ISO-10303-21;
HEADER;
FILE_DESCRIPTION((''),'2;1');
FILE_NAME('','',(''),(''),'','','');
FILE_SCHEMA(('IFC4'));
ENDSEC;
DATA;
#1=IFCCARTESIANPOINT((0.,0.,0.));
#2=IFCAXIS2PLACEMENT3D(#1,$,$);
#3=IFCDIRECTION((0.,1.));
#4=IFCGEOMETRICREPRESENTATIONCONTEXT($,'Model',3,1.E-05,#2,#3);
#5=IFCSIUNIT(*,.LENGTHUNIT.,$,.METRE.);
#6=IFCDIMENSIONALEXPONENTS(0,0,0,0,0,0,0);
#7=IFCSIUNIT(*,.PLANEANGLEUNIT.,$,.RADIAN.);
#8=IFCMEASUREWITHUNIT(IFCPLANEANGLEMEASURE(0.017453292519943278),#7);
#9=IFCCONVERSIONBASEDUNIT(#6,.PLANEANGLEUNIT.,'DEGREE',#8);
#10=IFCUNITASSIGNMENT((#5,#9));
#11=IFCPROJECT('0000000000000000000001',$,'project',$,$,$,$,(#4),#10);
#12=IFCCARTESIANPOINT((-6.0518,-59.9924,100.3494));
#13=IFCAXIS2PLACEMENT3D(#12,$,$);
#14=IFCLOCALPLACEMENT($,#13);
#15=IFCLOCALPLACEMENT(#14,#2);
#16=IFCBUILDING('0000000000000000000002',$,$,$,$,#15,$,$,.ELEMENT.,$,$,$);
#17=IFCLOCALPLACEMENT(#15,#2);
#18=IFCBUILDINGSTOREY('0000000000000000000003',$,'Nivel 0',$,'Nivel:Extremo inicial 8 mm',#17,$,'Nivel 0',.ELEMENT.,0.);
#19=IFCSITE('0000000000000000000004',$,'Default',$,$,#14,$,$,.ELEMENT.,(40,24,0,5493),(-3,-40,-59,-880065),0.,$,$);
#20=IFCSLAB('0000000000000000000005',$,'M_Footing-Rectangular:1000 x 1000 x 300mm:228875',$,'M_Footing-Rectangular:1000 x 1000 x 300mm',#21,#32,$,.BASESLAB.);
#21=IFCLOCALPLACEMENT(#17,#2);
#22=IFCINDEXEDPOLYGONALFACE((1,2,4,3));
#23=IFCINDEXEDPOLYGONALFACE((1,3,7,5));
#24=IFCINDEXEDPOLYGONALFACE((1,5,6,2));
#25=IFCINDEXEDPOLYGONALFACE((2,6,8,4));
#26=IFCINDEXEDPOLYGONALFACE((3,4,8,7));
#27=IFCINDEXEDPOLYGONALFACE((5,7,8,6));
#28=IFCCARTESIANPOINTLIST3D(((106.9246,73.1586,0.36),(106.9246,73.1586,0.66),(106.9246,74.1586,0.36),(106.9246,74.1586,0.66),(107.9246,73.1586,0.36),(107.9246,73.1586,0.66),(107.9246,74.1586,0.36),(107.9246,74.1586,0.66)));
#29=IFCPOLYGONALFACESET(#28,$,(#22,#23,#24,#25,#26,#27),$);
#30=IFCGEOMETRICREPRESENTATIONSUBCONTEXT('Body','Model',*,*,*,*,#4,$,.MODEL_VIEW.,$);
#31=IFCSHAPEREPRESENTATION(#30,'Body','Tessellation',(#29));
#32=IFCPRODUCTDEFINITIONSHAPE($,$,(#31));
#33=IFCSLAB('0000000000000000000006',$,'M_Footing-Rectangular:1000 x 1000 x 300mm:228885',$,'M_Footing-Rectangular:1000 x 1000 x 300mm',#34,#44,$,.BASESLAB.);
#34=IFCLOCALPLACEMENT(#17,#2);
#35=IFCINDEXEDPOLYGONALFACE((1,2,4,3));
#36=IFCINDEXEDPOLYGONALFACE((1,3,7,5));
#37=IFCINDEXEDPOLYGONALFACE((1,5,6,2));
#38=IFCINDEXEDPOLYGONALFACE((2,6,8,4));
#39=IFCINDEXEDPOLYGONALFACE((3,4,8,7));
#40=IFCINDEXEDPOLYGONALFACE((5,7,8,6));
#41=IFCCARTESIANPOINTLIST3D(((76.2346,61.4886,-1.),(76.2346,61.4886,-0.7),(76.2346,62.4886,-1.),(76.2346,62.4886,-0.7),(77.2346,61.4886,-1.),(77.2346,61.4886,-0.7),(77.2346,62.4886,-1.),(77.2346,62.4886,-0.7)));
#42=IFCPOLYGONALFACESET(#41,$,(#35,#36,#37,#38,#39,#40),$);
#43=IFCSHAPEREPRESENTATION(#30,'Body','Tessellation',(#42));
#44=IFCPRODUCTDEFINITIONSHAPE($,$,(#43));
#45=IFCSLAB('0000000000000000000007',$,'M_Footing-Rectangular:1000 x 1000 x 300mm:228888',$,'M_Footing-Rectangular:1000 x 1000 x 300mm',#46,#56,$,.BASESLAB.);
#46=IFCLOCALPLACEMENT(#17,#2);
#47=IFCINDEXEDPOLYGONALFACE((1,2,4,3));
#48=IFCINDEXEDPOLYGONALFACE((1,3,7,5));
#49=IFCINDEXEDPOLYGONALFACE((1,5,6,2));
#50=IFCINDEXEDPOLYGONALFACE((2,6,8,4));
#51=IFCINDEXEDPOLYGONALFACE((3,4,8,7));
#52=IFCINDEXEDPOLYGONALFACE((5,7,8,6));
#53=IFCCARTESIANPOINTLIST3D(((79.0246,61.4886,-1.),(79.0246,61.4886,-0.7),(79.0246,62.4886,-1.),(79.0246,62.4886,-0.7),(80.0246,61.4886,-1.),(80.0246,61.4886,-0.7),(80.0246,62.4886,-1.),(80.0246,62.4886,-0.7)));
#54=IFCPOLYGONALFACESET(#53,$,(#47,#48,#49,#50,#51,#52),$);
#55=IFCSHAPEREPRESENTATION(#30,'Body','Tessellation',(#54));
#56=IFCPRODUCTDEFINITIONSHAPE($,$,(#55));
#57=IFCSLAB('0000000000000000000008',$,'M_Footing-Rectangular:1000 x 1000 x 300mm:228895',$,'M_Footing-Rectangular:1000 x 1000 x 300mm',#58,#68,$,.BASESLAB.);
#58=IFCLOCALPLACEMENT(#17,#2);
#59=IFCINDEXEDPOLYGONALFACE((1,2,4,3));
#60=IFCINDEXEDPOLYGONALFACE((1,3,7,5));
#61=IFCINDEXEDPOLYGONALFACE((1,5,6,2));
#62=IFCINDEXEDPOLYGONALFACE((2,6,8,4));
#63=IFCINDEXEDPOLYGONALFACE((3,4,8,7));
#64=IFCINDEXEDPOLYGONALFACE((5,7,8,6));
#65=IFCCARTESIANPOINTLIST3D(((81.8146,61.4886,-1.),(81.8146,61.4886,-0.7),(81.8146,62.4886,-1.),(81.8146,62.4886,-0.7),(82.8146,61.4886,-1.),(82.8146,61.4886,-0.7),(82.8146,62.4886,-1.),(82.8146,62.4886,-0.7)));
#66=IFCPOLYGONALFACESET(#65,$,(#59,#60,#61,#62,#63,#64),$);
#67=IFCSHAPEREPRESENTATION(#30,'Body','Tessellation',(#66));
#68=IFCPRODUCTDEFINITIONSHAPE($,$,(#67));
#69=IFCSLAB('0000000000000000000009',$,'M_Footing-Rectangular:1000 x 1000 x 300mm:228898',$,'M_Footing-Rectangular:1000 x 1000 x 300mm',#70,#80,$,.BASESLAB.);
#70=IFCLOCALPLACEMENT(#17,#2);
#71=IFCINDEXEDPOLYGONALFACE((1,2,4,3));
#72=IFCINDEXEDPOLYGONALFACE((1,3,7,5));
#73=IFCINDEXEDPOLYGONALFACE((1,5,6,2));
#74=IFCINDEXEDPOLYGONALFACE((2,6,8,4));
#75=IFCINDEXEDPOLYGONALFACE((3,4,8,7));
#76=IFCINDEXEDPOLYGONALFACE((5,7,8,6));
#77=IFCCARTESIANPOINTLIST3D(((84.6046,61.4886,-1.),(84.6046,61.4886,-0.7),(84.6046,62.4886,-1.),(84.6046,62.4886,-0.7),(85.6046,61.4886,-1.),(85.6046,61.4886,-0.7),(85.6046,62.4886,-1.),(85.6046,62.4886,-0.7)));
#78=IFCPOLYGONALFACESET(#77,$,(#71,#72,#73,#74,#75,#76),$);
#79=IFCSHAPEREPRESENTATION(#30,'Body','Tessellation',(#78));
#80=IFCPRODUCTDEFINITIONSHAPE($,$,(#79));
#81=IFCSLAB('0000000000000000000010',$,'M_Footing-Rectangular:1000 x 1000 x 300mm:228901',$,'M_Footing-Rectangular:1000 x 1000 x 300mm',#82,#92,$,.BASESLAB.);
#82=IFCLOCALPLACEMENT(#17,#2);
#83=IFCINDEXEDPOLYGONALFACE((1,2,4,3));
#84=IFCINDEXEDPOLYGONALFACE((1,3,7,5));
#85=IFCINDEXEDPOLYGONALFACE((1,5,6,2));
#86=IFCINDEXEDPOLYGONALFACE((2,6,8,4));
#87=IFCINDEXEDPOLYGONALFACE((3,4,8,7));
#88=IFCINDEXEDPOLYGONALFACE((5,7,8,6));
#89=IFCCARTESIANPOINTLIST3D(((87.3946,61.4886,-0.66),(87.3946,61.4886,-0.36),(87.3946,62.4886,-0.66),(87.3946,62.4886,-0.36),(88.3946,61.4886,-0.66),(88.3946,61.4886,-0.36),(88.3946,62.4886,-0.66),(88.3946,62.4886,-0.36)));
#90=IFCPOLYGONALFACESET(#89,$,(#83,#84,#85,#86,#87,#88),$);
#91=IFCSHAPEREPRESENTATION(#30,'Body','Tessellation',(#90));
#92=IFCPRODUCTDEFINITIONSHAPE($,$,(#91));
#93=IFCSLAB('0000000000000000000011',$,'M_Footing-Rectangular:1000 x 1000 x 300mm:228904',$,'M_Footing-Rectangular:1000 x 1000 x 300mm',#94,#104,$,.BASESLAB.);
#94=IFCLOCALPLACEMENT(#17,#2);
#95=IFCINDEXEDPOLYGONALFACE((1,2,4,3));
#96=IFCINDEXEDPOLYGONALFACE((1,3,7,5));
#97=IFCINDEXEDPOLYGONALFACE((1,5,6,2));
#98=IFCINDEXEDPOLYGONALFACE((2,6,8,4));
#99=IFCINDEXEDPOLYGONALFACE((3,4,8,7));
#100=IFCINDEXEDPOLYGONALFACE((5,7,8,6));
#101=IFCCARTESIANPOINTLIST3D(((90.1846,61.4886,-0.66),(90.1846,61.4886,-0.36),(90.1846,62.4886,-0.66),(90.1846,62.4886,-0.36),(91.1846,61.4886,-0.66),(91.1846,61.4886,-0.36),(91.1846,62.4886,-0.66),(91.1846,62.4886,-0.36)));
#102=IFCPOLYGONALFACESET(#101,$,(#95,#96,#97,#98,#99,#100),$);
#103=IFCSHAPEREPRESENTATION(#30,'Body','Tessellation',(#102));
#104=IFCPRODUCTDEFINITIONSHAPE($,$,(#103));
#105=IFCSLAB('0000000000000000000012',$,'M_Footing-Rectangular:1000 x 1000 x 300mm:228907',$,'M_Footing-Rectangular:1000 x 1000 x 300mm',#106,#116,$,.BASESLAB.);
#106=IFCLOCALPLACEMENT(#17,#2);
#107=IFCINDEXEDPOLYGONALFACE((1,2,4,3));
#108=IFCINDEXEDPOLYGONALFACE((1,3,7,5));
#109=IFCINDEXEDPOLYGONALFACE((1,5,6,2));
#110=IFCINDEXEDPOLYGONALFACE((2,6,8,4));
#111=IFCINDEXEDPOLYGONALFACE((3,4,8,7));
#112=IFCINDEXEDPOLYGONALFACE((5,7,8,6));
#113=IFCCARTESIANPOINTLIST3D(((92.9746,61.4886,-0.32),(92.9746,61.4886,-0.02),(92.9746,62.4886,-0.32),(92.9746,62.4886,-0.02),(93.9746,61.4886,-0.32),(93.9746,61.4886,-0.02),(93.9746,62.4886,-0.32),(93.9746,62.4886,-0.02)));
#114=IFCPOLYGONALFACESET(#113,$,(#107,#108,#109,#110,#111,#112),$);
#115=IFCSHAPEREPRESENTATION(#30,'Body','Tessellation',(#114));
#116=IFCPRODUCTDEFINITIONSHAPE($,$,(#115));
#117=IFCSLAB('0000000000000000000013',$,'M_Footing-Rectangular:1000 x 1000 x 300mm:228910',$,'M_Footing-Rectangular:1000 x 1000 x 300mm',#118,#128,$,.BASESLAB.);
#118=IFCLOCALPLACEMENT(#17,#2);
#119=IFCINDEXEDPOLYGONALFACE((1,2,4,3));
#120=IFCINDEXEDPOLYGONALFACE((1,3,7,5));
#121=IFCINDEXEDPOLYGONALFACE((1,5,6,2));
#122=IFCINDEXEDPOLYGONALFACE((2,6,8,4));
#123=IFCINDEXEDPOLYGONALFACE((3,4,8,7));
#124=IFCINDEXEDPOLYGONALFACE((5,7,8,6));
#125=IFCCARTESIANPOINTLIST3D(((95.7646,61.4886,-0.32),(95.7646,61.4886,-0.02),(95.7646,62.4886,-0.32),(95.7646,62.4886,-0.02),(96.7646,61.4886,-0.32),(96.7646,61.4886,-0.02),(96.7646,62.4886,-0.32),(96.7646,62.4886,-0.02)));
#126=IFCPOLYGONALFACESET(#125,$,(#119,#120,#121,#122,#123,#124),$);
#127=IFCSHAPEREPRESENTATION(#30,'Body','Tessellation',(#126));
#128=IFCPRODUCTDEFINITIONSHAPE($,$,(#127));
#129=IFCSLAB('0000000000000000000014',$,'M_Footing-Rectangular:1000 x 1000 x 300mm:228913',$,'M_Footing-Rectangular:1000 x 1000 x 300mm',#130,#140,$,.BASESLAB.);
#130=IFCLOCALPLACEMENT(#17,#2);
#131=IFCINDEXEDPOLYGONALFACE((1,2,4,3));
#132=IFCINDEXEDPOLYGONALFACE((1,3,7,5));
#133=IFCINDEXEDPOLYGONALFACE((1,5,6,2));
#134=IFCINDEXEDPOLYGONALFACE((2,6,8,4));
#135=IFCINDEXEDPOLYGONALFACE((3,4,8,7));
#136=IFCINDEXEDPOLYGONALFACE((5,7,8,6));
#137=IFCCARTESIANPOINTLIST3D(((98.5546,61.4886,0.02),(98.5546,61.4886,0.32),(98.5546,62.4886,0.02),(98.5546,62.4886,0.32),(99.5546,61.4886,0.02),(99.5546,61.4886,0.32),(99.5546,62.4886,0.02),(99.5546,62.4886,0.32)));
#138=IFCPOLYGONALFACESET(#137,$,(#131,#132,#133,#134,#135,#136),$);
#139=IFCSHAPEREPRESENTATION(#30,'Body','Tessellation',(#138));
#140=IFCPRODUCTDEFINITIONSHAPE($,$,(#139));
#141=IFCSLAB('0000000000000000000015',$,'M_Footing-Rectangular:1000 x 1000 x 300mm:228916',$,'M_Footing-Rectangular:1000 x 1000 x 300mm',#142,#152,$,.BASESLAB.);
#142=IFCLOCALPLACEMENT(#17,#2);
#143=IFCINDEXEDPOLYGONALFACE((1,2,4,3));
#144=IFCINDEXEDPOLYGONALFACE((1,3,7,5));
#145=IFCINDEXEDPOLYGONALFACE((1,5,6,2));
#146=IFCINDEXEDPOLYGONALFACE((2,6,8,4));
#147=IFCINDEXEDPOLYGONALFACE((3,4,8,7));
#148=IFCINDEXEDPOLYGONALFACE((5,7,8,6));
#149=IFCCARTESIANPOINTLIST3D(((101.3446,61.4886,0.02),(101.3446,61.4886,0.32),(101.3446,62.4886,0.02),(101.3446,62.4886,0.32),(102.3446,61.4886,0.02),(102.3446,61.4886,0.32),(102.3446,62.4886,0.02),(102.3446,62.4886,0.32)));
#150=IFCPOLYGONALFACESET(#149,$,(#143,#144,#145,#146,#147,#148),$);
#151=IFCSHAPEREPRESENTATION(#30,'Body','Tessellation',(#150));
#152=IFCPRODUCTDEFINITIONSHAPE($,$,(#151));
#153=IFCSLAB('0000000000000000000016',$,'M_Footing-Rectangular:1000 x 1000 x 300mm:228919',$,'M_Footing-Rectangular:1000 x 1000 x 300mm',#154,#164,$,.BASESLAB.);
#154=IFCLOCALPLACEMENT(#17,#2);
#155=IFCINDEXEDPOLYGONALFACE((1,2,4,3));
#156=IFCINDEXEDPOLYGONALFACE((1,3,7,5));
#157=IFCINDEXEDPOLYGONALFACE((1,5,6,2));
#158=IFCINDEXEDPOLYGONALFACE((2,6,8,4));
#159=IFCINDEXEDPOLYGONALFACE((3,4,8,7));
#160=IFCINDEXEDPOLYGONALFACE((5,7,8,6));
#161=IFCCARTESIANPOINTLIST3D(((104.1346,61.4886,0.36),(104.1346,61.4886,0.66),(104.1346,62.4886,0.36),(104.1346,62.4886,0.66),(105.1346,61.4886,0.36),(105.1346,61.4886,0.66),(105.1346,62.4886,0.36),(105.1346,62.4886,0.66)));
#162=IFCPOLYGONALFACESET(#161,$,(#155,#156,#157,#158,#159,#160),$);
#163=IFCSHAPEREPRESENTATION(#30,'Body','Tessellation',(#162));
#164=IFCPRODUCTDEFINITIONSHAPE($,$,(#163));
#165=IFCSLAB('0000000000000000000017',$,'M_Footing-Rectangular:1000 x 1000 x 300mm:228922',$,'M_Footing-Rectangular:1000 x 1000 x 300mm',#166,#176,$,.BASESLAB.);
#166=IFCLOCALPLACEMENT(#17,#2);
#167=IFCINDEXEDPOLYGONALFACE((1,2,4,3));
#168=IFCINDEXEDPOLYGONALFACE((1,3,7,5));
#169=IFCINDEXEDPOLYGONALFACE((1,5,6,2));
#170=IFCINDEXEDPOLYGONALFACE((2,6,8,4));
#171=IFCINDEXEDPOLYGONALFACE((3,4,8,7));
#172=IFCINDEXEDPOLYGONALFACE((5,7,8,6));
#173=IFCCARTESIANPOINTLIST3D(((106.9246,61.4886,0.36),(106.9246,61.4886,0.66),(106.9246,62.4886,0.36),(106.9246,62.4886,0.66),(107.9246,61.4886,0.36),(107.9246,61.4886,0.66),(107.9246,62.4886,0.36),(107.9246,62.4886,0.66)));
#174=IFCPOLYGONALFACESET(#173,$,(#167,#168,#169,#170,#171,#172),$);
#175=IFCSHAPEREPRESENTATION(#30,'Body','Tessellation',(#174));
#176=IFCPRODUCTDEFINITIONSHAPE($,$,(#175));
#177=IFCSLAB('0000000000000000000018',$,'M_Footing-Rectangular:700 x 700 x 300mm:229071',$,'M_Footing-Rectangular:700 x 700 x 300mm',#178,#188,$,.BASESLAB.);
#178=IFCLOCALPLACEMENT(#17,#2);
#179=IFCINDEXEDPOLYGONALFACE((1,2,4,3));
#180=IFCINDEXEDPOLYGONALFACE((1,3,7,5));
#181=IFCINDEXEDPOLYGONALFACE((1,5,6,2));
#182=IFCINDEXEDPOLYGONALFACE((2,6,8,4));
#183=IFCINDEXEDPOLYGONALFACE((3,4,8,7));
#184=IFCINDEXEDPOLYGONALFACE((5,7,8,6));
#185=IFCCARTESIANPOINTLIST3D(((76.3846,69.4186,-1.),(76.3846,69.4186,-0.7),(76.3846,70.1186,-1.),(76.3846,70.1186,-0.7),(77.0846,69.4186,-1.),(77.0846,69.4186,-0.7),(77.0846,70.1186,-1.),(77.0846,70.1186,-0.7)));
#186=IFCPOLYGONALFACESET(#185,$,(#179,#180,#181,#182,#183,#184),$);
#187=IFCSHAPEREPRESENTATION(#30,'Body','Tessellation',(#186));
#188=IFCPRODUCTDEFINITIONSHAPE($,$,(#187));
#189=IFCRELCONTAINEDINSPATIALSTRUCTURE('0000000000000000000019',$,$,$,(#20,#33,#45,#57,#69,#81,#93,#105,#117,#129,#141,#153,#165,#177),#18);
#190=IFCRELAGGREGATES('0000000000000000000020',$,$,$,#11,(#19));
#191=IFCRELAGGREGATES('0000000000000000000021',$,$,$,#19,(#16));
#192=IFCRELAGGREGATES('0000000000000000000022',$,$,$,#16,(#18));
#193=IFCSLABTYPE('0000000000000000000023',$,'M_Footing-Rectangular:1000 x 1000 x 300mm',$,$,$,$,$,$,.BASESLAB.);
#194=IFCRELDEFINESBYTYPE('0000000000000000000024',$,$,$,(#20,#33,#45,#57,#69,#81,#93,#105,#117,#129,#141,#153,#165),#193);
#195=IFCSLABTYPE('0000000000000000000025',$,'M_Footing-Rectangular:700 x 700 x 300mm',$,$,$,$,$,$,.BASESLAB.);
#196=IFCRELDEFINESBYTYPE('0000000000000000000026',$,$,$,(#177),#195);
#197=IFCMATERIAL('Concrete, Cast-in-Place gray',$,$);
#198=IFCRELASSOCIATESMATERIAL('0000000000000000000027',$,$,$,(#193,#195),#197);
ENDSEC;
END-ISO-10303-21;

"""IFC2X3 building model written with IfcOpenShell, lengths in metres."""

from ifc_helpers import new_model, entity, si_unit, converted_unit, direction, frame, frame_2d, origin, origin_2d_with_axis, place, context, subcontext, project, spatial, rectangle, extrude, material, type_object, element, save


model = new_model("IFC2X3")

# Units and contexts
model_context = context("Model", 3, precision=1e-05, world=origin(), true_north=direction((0.0, 1.0)))
body_context = subcontext(model_context, "Body", "Model", "MODEL_VIEW")
ifc_project = project(units=[si_unit("LENGTHUNIT", "METRE"), converted_unit("PLANEANGLEUNIT", "DEGREE", entity("IfcPlaneAngleMeasure", 0.017453292519943278), si_unit("PLANEANGLEUNIT", "RADIAN"), dimensions=[0, 0, 0, 0, 0, 0, 0])], contexts=[model_context])

# Site, building, storey
site_placement = place(None, frame((-6.0518, -59.9924, 100.3494)))
site = spatial("IfcSite", under=ifc_project, at=site_placement, Name="Default", CompositionType="ELEMENT", RefLatitude=(40, 24, 0, 5493), RefLongitude=(-3, -40, -59, -880065), RefElevation=0.0)
building_placement = place(site_placement, origin())
building = spatial("IfcBuilding", under=site, at=building_placement, CompositionType="ELEMENT")
storey_placement = place(building_placement, origin())
storey = spatial("IfcBuildingStorey", under=building, at=storey_placement, Name="Nivel 0", ObjectType="Nivel:Extremo inicial 8 mm", LongName="Nivel 0", CompositionType="ELEMENT", Elevation=0.0)

# Shared definitions
ifc_material = material(Name="Concrete, Cast-in-Place gray")

# Slabs
slab_type_1 = type_object("IfcSlabType", Name="M_Footing-Rectangular:1000 x 1000 x 300mm", PredefinedType="BASESLAB", material=ifc_material)
slab_1_placement = place(storey_placement, origin())
element("IfcSlab", 1, at=slab_1_placement, inside=storey, type_object=slab_type_1, Name="M_Footing-Rectangular:1000 x 1000 x 300mm:228875", ObjectType="M_Footing-Rectangular:1000 x 1000 x 300mm", PredefinedType="BASESLAB", context=body_context, shape_type="SweptSolid", body=[
    extrude(rectangle(XDim=1.0, YDim=1.0, at=frame_2d((0.0, 0.0), x_axis=(1.0, 0.0))), frame((107.4246, 73.6586, 0.36), z_axis=(0.0, 0.0, 1.0), x_axis=(-1.0, 0.0, 0.0)), (0.0, 0.0, 1.0), 0.3),
])
slab_2_placement = place(storey_placement, origin())
element("IfcSlab", 2, at=slab_2_placement, inside=storey, type_object=slab_type_1, Name="M_Footing-Rectangular:1000 x 1000 x 300mm:228885", ObjectType="M_Footing-Rectangular:1000 x 1000 x 300mm", PredefinedType="BASESLAB", context=body_context, shape_type="SweptSolid", body=[
    extrude(rectangle(XDim=1.0, YDim=1.0, at=origin_2d_with_axis()), frame((76.7346, 61.9886, -1.0), z_axis=(0.0, 0.0, 1.0), x_axis=(-1.0, 0.0, 0.0)), (0.0, 0.0, 1.0), 0.3),
])
slab_3_placement = place(storey_placement, origin())
element("IfcSlab", 3, at=slab_3_placement, inside=storey, type_object=slab_type_1, Name="M_Footing-Rectangular:1000 x 1000 x 300mm:228888", ObjectType="M_Footing-Rectangular:1000 x 1000 x 300mm", PredefinedType="BASESLAB", context=body_context, shape_type="SweptSolid", body=[
    extrude(rectangle(XDim=1.0, YDim=1.0, at=frame_2d((0.0, 0.0), x_axis=(1.0, 0.0))), frame((79.5246, 61.9886, -1.0), z_axis=(0.0, 0.0, 1.0), x_axis=(-1.0, 0.0, 0.0)), (0.0, 0.0, 1.0), 0.3),
])
slab_4_placement = place(storey_placement, origin())
element("IfcSlab", 4, at=slab_4_placement, inside=storey, type_object=slab_type_1, Name="M_Footing-Rectangular:1000 x 1000 x 300mm:228895", ObjectType="M_Footing-Rectangular:1000 x 1000 x 300mm", PredefinedType="BASESLAB", context=body_context, shape_type="SweptSolid", body=[
    extrude(rectangle(XDim=1.0, YDim=1.0, at=frame_2d((0.0, 0.0), x_axis=(1.0, 0.0))), frame((82.3146, 61.9886, -1.0), z_axis=(0.0, 0.0, 1.0), x_axis=(-1.0, 0.0, 0.0)), (0.0, 0.0, 1.0), 0.3),
])
slab_5_placement = place(storey_placement, origin())
element("IfcSlab", 5, at=slab_5_placement, inside=storey, type_object=slab_type_1, Name="M_Footing-Rectangular:1000 x 1000 x 300mm:228898", ObjectType="M_Footing-Rectangular:1000 x 1000 x 300mm", PredefinedType="BASESLAB", context=body_context, shape_type="SweptSolid", body=[
    extrude(rectangle(XDim=1.0, YDim=1.0, at=frame_2d((0.0, 0.0), x_axis=(1.0, 0.0))), frame((85.1046, 61.9886, -1.0), z_axis=(0.0, 0.0, 1.0), x_axis=(-1.0, 0.0, 0.0)), (0.0, 0.0, 1.0), 0.3),
])
slab_6_placement = place(storey_placement, origin())
element("IfcSlab", 6, at=slab_6_placement, inside=storey, type_object=slab_type_1, Name="M_Footing-Rectangular:1000 x 1000 x 300mm:228901", ObjectType="M_Footing-Rectangular:1000 x 1000 x 300mm", PredefinedType="BASESLAB", context=body_context, shape_type="SweptSolid", body=[
    extrude(rectangle(XDim=1.0, YDim=1.0, at=frame_2d((0.0, 0.0), x_axis=(1.0, 0.0))), frame((87.8946, 61.9886, -0.66), z_axis=(0.0, 0.0, 1.0), x_axis=(-1.0, 0.0, 0.0)), (0.0, 0.0, 1.0), 0.3),
])
slab_7_placement = place(storey_placement, origin())
element("IfcSlab", 7, at=slab_7_placement, inside=storey, type_object=slab_type_1, Name="M_Footing-Rectangular:1000 x 1000 x 300mm:228904", ObjectType="M_Footing-Rectangular:1000 x 1000 x 300mm", PredefinedType="BASESLAB", context=body_context, shape_type="SweptSolid", body=[
    extrude(rectangle(XDim=1.0, YDim=1.0, at=frame_2d((0.0, 0.0), x_axis=(1.0, 0.0))), frame((90.6846, 61.9886, -0.66), z_axis=(0.0, 0.0, 1.0), x_axis=(-1.0, 0.0, 0.0)), (0.0, 0.0, 1.0), 0.3),
])
slab_8_placement = place(storey_placement, origin())
element("IfcSlab", 8, at=slab_8_placement, inside=storey, type_object=slab_type_1, Name="M_Footing-Rectangular:1000 x 1000 x 300mm:228907", ObjectType="M_Footing-Rectangular:1000 x 1000 x 300mm", PredefinedType="BASESLAB", context=body_context, shape_type="SweptSolid", body=[
    extrude(rectangle(XDim=1.0, YDim=1.0, at=frame_2d((0.0, 0.0), x_axis=(1.0, 0.0))), frame((93.4746, 61.9886, -0.32), z_axis=(0.0, 0.0, 1.0), x_axis=(-1.0, 0.0, 0.0)), (0.0, 0.0, 1.0), 0.3),
])
slab_9_placement = place(storey_placement, origin())
element("IfcSlab", 9, at=slab_9_placement, inside=storey, type_object=slab_type_1, Name="M_Footing-Rectangular:1000 x 1000 x 300mm:228910", ObjectType="M_Footing-Rectangular:1000 x 1000 x 300mm", PredefinedType="BASESLAB", context=body_context, shape_type="SweptSolid", body=[
    extrude(rectangle(XDim=1.0, YDim=1.0, at=frame_2d((0.0, 0.0), x_axis=(1.0, 0.0))), frame((96.2646, 61.9886, -0.32), z_axis=(0.0, 0.0, 1.0), x_axis=(-1.0, 0.0, 0.0)), (0.0, 0.0, 1.0), 0.3),
])
slab_10_placement = place(storey_placement, origin())
element("IfcSlab", 10, at=slab_10_placement, inside=storey, type_object=slab_type_1, Name="M_Footing-Rectangular:1000 x 1000 x 300mm:228913", ObjectType="M_Footing-Rectangular:1000 x 1000 x 300mm", PredefinedType="BASESLAB", context=body_context, shape_type="SweptSolid", body=[
    extrude(rectangle(XDim=1.0, YDim=1.0, at=frame_2d((0.0, 0.0), x_axis=(1.0, 0.0))), frame((99.0546, 61.9886, 0.02), z_axis=(0.0, 0.0, 1.0), x_axis=(-1.0, 0.0, 0.0)), (0.0, 0.0, 1.0), 0.3),
])
slab_11_placement = place(storey_placement, origin())
element("IfcSlab", 11, at=slab_11_placement, inside=storey, type_object=slab_type_1, Name="M_Footing-Rectangular:1000 x 1000 x 300mm:228916", ObjectType="M_Footing-Rectangular:1000 x 1000 x 300mm", PredefinedType="BASESLAB", context=body_context, shape_type="SweptSolid", body=[
    extrude(rectangle(XDim=1.0, YDim=1.0, at=frame_2d((0.0, 0.0), x_axis=(1.0, 0.0))), frame((101.8446, 61.9886, 0.02), z_axis=(0.0, 0.0, 1.0), x_axis=(-1.0, 0.0, 0.0)), (0.0, 0.0, 1.0), 0.3),
])
slab_12_placement = place(storey_placement, origin())
element("IfcSlab", 12, at=slab_12_placement, inside=storey, type_object=slab_type_1, Name="M_Footing-Rectangular:1000 x 1000 x 300mm:228919", ObjectType="M_Footing-Rectangular:1000 x 1000 x 300mm", PredefinedType="BASESLAB", context=body_context, shape_type="SweptSolid", body=[
    extrude(rectangle(XDim=1.0, YDim=1.0, at=frame_2d((0.0, 0.0), x_axis=(1.0, 0.0))), frame((104.6346, 61.9886, 0.36), z_axis=(0.0, 0.0, 1.0), x_axis=(-1.0, 0.0, 0.0)), (0.0, 0.0, 1.0), 0.3),
])
slab_13_placement = place(storey_placement, origin())
element("IfcSlab", 13, at=slab_13_placement, inside=storey, type_object=slab_type_1, Name="M_Footing-Rectangular:1000 x 1000 x 300mm:228922", ObjectType="M_Footing-Rectangular:1000 x 1000 x 300mm", PredefinedType="BASESLAB", context=body_context, shape_type="SweptSolid", body=[
    extrude(rectangle(XDim=1.0, YDim=1.0, at=frame_2d((0.0, 0.0), x_axis=(1.0, 0.0))), frame((107.4246, 61.9886, 0.36), z_axis=(0.0, 0.0, 1.0), x_axis=(-1.0, 0.0, 0.0)), (0.0, 0.0, 1.0), 0.3),
])
slab_type_2 = type_object("IfcSlabType", Name="M_Footing-Rectangular:700 x 700 x 300mm", PredefinedType="BASESLAB", material=ifc_material)
slab_14_placement = place(storey_placement, origin())
element("IfcSlab", 14, at=slab_14_placement, inside=storey, type_object=slab_type_2, Name="M_Footing-Rectangular:700 x 700 x 300mm:229071", ObjectType="M_Footing-Rectangular:700 x 700 x 300mm", PredefinedType="BASESLAB", context=body_context, shape_type="SweptSolid", body=[
    extrude(rectangle(XDim=0.7, YDim=0.7, at=frame_2d((0.0, 0.0), x_axis=(1.0, 0.0))), frame((76.7346, 69.7686, -1.0), z_axis=(0.0, 0.0, 1.0), x_axis=(-1.0, 0.0, 0.0)), (0.0, 0.0, 1.0), 0.3),
])

save(model, "model.ifc")
